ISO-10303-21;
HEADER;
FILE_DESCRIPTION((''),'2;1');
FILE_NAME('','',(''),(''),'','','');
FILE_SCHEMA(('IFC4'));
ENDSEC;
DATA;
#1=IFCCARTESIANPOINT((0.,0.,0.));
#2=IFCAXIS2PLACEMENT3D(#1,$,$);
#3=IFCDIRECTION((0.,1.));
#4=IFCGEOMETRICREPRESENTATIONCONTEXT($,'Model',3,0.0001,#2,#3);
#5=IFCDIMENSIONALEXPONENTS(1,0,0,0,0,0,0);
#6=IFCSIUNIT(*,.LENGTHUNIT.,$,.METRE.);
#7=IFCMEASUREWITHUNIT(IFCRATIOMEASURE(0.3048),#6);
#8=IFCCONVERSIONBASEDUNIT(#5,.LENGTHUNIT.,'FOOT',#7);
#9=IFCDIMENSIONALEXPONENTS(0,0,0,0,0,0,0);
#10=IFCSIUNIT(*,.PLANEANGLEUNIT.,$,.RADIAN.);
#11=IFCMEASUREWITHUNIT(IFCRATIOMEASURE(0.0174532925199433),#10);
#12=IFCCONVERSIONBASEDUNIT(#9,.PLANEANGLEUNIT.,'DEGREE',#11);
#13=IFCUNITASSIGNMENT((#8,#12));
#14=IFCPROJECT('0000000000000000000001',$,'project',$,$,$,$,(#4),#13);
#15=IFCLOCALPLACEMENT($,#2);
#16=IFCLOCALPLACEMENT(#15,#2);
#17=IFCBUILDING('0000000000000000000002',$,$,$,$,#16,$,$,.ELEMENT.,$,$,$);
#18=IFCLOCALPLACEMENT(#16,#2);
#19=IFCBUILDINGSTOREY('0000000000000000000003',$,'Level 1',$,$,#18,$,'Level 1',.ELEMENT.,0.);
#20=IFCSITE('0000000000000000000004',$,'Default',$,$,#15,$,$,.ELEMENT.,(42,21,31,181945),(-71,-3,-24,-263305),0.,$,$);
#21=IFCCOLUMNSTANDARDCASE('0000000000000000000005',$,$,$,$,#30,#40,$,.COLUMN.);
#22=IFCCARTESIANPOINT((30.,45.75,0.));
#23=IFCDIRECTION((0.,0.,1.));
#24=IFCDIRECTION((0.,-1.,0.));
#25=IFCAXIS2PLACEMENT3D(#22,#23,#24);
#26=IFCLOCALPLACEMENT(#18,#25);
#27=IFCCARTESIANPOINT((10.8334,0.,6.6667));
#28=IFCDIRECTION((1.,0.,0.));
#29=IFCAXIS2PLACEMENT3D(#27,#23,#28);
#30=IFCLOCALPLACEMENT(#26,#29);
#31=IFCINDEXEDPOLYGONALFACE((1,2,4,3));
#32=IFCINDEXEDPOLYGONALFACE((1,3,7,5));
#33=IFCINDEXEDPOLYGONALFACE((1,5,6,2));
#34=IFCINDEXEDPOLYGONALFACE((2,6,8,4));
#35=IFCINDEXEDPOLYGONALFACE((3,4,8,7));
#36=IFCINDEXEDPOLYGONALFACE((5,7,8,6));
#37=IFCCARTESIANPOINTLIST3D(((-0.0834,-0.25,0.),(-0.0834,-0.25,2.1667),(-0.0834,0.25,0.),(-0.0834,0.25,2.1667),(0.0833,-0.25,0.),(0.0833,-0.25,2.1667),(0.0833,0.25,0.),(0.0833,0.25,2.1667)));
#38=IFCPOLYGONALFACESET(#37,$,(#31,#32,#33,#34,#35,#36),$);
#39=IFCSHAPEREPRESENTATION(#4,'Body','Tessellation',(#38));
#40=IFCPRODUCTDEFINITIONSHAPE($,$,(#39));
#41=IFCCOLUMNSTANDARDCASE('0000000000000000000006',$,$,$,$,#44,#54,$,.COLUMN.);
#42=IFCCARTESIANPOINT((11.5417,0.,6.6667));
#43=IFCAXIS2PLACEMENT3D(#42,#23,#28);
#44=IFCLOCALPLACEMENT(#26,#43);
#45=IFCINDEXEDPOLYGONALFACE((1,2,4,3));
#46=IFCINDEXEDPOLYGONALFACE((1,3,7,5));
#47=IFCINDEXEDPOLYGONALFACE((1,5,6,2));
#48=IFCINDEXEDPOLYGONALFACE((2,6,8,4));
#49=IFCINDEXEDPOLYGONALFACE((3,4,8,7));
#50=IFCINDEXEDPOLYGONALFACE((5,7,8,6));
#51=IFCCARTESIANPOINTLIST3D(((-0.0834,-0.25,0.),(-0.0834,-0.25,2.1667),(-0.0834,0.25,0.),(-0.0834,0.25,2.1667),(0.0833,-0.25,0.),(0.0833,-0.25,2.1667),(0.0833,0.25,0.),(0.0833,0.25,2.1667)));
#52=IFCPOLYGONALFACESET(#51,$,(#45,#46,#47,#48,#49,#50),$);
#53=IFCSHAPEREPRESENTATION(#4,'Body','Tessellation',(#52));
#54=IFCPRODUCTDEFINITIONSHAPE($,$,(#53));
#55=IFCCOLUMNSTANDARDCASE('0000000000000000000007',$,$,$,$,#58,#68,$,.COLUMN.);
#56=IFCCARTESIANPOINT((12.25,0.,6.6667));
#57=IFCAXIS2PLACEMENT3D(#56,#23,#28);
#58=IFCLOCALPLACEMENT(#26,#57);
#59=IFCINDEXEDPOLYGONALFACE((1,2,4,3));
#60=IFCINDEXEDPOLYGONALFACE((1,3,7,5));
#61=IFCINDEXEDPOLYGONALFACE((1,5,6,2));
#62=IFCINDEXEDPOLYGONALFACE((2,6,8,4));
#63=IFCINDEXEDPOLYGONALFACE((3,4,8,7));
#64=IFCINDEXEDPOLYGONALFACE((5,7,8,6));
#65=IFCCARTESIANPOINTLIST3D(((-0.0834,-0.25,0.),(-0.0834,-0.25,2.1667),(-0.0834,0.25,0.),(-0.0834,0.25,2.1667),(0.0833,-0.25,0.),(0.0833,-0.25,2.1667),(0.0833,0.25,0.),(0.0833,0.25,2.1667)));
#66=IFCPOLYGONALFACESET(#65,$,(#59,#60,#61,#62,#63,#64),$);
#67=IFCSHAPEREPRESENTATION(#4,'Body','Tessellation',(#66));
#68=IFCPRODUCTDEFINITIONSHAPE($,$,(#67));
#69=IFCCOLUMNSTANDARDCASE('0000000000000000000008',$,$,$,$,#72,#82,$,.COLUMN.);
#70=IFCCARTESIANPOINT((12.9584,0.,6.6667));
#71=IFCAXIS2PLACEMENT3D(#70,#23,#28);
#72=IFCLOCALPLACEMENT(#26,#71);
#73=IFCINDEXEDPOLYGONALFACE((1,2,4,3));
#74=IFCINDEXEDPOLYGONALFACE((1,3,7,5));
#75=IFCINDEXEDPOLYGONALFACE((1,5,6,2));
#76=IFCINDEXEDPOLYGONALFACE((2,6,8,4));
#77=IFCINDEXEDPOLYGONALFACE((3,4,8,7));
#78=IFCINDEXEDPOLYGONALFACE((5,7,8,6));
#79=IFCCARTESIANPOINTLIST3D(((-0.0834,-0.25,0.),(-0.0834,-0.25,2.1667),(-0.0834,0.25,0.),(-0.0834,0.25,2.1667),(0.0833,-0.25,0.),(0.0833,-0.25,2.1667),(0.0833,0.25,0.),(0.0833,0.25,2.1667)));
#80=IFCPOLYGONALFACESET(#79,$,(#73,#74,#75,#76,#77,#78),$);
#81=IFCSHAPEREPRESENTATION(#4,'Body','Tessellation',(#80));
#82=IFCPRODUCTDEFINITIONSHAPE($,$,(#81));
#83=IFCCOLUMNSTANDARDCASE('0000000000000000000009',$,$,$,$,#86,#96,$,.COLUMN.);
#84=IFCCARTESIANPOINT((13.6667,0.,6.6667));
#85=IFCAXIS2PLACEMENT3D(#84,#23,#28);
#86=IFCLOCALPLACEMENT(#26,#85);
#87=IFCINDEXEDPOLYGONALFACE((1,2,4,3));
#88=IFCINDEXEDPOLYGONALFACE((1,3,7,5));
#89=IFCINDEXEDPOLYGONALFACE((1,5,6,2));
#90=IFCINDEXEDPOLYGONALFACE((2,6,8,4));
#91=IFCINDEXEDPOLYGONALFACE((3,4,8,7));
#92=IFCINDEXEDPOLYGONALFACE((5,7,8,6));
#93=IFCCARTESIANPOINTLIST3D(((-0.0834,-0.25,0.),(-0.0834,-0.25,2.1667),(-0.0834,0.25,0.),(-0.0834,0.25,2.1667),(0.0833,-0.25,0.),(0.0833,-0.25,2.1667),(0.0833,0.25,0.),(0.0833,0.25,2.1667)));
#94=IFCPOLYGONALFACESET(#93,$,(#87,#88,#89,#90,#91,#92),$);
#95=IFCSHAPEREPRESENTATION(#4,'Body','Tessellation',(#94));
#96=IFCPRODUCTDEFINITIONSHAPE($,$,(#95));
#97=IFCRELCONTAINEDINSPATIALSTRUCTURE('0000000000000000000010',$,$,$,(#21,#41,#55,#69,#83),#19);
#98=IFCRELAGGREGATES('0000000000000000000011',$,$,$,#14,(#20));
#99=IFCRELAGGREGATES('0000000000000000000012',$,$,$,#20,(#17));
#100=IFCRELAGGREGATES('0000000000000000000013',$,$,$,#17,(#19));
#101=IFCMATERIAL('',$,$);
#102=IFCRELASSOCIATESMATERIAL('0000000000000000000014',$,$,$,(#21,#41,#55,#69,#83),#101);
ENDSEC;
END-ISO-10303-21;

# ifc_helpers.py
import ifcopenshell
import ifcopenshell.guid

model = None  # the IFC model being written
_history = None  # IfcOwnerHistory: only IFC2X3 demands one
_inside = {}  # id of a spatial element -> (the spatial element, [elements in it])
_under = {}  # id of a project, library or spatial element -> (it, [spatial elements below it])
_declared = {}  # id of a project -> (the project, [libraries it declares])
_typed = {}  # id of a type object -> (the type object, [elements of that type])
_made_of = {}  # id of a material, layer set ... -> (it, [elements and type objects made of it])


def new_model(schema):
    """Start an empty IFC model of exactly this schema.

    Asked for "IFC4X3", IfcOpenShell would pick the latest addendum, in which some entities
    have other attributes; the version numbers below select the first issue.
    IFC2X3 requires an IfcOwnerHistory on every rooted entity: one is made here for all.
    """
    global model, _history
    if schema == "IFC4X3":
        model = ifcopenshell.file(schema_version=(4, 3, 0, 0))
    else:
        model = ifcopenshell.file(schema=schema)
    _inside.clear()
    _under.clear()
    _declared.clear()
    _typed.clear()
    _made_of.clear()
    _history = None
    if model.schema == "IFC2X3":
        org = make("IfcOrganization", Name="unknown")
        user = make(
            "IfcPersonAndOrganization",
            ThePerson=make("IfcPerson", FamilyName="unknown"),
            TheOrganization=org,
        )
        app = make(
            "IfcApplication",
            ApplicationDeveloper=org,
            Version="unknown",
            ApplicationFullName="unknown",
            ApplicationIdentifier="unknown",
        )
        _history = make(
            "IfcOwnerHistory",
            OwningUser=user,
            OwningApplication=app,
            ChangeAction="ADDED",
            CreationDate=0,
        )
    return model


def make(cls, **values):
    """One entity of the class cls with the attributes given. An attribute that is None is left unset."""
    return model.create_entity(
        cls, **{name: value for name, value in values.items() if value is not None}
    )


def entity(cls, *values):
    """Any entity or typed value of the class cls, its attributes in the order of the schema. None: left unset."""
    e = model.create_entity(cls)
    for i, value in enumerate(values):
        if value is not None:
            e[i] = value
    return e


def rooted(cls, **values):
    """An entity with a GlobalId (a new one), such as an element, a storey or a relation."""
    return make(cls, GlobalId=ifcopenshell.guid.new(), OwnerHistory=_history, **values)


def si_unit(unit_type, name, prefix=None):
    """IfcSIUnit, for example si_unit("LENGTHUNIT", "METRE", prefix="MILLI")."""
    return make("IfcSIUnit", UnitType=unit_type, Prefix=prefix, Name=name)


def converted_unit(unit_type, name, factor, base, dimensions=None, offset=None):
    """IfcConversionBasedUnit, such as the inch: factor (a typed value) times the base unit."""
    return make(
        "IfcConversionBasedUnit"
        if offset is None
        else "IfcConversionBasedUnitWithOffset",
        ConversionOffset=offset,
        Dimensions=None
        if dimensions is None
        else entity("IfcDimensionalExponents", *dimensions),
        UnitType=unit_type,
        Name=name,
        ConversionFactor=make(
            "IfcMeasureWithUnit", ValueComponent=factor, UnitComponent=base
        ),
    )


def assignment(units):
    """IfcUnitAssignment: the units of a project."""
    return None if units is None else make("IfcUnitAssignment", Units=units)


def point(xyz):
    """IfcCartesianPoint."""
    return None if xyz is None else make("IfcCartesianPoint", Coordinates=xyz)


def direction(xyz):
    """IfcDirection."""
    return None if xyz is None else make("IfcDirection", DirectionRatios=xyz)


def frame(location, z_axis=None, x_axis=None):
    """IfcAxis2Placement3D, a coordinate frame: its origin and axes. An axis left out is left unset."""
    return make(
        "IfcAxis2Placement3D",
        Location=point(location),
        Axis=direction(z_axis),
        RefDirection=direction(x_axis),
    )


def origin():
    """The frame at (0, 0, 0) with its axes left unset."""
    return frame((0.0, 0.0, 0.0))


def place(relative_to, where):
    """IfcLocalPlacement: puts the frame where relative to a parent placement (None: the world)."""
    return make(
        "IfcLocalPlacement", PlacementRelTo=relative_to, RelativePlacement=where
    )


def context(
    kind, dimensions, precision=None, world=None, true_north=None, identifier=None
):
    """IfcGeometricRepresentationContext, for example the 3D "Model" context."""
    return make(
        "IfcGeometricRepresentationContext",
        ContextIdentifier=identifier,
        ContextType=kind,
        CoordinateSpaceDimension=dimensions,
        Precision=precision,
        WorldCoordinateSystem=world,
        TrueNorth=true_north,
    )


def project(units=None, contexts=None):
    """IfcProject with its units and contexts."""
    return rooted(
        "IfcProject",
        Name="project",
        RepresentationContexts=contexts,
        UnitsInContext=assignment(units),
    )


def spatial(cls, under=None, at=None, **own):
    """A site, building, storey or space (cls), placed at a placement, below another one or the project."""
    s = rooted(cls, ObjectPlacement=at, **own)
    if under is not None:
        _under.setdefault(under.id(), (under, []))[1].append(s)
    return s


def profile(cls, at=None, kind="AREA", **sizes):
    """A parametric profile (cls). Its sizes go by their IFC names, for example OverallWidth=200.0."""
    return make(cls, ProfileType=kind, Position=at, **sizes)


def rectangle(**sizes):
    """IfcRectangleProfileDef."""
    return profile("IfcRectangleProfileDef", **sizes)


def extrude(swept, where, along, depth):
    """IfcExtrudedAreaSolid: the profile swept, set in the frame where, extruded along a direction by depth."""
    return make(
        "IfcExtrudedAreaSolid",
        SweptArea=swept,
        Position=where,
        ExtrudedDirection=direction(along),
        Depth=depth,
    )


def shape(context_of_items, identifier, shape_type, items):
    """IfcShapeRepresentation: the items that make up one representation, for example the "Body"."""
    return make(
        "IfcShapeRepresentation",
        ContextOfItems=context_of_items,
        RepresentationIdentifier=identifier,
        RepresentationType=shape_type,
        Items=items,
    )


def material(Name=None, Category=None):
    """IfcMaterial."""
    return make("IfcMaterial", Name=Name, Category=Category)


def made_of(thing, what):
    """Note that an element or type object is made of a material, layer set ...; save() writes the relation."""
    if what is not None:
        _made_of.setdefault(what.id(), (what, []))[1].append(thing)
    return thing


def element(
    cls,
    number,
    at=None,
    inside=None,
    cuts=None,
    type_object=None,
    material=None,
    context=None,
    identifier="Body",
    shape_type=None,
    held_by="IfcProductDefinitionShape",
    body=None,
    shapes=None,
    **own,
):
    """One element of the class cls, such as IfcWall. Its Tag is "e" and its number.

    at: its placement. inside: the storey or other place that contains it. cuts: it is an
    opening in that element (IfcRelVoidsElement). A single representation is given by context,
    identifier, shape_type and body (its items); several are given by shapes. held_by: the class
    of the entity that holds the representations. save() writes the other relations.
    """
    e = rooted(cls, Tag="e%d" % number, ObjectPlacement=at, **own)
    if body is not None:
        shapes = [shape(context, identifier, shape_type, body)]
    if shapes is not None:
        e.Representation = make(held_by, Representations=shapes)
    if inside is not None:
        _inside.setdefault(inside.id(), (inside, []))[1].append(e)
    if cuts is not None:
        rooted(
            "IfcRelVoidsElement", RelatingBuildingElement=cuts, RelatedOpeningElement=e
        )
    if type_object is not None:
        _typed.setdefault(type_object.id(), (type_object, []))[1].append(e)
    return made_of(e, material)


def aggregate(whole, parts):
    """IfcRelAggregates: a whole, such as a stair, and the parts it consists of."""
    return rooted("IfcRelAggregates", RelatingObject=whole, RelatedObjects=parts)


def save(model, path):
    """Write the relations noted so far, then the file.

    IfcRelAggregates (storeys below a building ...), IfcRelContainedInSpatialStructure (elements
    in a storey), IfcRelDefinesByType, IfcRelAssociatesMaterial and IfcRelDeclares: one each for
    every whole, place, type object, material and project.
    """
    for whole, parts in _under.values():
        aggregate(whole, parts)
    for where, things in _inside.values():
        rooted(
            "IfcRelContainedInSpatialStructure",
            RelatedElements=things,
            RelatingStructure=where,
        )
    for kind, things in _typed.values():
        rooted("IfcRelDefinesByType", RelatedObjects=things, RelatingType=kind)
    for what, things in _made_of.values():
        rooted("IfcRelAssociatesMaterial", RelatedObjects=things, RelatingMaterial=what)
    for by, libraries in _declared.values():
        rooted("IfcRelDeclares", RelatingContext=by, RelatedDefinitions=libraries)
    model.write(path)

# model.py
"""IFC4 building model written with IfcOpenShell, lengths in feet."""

from ifc_helpers import new_model, entity, si_unit, converted_unit, direction, frame, origin, place, context, project, spatial, rectangle, extrude, material, element, save


model = new_model("IFC4")

# Units and contexts
model_context = context("Model", 3, precision=0.0001, world=origin(), true_north=direction((0.0, 1.0)))
ifc_project = project(units=[converted_unit("LENGTHUNIT", "FOOT", entity("IfcRatioMeasure", 0.3048), si_unit("LENGTHUNIT", "METRE"), dimensions=[1, 0, 0, 0, 0, 0, 0]), converted_unit("PLANEANGLEUNIT", "DEGREE", entity("IfcRatioMeasure", 0.0174532925199433), si_unit("PLANEANGLEUNIT", "RADIAN"), dimensions=[0, 0, 0, 0, 0, 0, 0])], contexts=[model_context])

# Site, building, storey
site_placement = place(None, origin())
site = spatial("IfcSite", under=ifc_project, at=site_placement, Name="Default", CompositionType="ELEMENT", RefLatitude=(42, 21, 31, 181945), RefLongitude=(-71, -3, -24, -263305), RefElevation=0.0)
building_placement = place(site_placement, origin())
building = spatial("IfcBuilding", under=site, at=building_placement, CompositionType="ELEMENT")
storey_placement = place(building_placement, origin())
storey = spatial("IfcBuildingStorey", under=building, at=storey_placement, Name="Level 1", LongName="Level 1", CompositionType="ELEMENT", Elevation=0.0)

# Columns
placement_1 = place(storey_placement, frame((30.0, 45.75, 0.0), z_axis=(0.0, 0.0, 1.0), x_axis=(0.0, -1.0, 0.0)))
ifc_material_1 = material(Name="")
for number, where, z_axis, x_axis in (
    (1, (10.8334, 0.0, 6.6667), (0.0, 0.0, 1.0), (1.0, 0.0, 0.0)),
    (2, (11.5417, 0.0, 6.6667), (0.0, 0.0, 1.0), (1.0, 0.0, 0.0)),
    (3, (12.25, 0.0, 6.6667), (0.0, 0.0, 1.0), (1.0, 0.0, 0.0)),
    (4, (12.9584, 0.0, 6.6667), (0.0, 0.0, 1.0), (1.0, 0.0, 0.0)),
    (5, (13.6667, 0.0, 6.6667), (0.0, 0.0, 1.0), (1.0, 0.0, 0.0)),
):
    element("IfcColumnStandardCase", number, at=place(placement_1, frame(where, z_axis=z_axis, x_axis=x_axis)), inside=storey, material=ifc_material_1, PredefinedType="COLUMN", context=model_context, shape_type="SweptSolid", body=[
        extrude(rectangle(XDim=0.1667, YDim=0.5), origin(), (0.0, 0.0, 1.0), 2.1667),
    ])

save(model, "model.ifc")
